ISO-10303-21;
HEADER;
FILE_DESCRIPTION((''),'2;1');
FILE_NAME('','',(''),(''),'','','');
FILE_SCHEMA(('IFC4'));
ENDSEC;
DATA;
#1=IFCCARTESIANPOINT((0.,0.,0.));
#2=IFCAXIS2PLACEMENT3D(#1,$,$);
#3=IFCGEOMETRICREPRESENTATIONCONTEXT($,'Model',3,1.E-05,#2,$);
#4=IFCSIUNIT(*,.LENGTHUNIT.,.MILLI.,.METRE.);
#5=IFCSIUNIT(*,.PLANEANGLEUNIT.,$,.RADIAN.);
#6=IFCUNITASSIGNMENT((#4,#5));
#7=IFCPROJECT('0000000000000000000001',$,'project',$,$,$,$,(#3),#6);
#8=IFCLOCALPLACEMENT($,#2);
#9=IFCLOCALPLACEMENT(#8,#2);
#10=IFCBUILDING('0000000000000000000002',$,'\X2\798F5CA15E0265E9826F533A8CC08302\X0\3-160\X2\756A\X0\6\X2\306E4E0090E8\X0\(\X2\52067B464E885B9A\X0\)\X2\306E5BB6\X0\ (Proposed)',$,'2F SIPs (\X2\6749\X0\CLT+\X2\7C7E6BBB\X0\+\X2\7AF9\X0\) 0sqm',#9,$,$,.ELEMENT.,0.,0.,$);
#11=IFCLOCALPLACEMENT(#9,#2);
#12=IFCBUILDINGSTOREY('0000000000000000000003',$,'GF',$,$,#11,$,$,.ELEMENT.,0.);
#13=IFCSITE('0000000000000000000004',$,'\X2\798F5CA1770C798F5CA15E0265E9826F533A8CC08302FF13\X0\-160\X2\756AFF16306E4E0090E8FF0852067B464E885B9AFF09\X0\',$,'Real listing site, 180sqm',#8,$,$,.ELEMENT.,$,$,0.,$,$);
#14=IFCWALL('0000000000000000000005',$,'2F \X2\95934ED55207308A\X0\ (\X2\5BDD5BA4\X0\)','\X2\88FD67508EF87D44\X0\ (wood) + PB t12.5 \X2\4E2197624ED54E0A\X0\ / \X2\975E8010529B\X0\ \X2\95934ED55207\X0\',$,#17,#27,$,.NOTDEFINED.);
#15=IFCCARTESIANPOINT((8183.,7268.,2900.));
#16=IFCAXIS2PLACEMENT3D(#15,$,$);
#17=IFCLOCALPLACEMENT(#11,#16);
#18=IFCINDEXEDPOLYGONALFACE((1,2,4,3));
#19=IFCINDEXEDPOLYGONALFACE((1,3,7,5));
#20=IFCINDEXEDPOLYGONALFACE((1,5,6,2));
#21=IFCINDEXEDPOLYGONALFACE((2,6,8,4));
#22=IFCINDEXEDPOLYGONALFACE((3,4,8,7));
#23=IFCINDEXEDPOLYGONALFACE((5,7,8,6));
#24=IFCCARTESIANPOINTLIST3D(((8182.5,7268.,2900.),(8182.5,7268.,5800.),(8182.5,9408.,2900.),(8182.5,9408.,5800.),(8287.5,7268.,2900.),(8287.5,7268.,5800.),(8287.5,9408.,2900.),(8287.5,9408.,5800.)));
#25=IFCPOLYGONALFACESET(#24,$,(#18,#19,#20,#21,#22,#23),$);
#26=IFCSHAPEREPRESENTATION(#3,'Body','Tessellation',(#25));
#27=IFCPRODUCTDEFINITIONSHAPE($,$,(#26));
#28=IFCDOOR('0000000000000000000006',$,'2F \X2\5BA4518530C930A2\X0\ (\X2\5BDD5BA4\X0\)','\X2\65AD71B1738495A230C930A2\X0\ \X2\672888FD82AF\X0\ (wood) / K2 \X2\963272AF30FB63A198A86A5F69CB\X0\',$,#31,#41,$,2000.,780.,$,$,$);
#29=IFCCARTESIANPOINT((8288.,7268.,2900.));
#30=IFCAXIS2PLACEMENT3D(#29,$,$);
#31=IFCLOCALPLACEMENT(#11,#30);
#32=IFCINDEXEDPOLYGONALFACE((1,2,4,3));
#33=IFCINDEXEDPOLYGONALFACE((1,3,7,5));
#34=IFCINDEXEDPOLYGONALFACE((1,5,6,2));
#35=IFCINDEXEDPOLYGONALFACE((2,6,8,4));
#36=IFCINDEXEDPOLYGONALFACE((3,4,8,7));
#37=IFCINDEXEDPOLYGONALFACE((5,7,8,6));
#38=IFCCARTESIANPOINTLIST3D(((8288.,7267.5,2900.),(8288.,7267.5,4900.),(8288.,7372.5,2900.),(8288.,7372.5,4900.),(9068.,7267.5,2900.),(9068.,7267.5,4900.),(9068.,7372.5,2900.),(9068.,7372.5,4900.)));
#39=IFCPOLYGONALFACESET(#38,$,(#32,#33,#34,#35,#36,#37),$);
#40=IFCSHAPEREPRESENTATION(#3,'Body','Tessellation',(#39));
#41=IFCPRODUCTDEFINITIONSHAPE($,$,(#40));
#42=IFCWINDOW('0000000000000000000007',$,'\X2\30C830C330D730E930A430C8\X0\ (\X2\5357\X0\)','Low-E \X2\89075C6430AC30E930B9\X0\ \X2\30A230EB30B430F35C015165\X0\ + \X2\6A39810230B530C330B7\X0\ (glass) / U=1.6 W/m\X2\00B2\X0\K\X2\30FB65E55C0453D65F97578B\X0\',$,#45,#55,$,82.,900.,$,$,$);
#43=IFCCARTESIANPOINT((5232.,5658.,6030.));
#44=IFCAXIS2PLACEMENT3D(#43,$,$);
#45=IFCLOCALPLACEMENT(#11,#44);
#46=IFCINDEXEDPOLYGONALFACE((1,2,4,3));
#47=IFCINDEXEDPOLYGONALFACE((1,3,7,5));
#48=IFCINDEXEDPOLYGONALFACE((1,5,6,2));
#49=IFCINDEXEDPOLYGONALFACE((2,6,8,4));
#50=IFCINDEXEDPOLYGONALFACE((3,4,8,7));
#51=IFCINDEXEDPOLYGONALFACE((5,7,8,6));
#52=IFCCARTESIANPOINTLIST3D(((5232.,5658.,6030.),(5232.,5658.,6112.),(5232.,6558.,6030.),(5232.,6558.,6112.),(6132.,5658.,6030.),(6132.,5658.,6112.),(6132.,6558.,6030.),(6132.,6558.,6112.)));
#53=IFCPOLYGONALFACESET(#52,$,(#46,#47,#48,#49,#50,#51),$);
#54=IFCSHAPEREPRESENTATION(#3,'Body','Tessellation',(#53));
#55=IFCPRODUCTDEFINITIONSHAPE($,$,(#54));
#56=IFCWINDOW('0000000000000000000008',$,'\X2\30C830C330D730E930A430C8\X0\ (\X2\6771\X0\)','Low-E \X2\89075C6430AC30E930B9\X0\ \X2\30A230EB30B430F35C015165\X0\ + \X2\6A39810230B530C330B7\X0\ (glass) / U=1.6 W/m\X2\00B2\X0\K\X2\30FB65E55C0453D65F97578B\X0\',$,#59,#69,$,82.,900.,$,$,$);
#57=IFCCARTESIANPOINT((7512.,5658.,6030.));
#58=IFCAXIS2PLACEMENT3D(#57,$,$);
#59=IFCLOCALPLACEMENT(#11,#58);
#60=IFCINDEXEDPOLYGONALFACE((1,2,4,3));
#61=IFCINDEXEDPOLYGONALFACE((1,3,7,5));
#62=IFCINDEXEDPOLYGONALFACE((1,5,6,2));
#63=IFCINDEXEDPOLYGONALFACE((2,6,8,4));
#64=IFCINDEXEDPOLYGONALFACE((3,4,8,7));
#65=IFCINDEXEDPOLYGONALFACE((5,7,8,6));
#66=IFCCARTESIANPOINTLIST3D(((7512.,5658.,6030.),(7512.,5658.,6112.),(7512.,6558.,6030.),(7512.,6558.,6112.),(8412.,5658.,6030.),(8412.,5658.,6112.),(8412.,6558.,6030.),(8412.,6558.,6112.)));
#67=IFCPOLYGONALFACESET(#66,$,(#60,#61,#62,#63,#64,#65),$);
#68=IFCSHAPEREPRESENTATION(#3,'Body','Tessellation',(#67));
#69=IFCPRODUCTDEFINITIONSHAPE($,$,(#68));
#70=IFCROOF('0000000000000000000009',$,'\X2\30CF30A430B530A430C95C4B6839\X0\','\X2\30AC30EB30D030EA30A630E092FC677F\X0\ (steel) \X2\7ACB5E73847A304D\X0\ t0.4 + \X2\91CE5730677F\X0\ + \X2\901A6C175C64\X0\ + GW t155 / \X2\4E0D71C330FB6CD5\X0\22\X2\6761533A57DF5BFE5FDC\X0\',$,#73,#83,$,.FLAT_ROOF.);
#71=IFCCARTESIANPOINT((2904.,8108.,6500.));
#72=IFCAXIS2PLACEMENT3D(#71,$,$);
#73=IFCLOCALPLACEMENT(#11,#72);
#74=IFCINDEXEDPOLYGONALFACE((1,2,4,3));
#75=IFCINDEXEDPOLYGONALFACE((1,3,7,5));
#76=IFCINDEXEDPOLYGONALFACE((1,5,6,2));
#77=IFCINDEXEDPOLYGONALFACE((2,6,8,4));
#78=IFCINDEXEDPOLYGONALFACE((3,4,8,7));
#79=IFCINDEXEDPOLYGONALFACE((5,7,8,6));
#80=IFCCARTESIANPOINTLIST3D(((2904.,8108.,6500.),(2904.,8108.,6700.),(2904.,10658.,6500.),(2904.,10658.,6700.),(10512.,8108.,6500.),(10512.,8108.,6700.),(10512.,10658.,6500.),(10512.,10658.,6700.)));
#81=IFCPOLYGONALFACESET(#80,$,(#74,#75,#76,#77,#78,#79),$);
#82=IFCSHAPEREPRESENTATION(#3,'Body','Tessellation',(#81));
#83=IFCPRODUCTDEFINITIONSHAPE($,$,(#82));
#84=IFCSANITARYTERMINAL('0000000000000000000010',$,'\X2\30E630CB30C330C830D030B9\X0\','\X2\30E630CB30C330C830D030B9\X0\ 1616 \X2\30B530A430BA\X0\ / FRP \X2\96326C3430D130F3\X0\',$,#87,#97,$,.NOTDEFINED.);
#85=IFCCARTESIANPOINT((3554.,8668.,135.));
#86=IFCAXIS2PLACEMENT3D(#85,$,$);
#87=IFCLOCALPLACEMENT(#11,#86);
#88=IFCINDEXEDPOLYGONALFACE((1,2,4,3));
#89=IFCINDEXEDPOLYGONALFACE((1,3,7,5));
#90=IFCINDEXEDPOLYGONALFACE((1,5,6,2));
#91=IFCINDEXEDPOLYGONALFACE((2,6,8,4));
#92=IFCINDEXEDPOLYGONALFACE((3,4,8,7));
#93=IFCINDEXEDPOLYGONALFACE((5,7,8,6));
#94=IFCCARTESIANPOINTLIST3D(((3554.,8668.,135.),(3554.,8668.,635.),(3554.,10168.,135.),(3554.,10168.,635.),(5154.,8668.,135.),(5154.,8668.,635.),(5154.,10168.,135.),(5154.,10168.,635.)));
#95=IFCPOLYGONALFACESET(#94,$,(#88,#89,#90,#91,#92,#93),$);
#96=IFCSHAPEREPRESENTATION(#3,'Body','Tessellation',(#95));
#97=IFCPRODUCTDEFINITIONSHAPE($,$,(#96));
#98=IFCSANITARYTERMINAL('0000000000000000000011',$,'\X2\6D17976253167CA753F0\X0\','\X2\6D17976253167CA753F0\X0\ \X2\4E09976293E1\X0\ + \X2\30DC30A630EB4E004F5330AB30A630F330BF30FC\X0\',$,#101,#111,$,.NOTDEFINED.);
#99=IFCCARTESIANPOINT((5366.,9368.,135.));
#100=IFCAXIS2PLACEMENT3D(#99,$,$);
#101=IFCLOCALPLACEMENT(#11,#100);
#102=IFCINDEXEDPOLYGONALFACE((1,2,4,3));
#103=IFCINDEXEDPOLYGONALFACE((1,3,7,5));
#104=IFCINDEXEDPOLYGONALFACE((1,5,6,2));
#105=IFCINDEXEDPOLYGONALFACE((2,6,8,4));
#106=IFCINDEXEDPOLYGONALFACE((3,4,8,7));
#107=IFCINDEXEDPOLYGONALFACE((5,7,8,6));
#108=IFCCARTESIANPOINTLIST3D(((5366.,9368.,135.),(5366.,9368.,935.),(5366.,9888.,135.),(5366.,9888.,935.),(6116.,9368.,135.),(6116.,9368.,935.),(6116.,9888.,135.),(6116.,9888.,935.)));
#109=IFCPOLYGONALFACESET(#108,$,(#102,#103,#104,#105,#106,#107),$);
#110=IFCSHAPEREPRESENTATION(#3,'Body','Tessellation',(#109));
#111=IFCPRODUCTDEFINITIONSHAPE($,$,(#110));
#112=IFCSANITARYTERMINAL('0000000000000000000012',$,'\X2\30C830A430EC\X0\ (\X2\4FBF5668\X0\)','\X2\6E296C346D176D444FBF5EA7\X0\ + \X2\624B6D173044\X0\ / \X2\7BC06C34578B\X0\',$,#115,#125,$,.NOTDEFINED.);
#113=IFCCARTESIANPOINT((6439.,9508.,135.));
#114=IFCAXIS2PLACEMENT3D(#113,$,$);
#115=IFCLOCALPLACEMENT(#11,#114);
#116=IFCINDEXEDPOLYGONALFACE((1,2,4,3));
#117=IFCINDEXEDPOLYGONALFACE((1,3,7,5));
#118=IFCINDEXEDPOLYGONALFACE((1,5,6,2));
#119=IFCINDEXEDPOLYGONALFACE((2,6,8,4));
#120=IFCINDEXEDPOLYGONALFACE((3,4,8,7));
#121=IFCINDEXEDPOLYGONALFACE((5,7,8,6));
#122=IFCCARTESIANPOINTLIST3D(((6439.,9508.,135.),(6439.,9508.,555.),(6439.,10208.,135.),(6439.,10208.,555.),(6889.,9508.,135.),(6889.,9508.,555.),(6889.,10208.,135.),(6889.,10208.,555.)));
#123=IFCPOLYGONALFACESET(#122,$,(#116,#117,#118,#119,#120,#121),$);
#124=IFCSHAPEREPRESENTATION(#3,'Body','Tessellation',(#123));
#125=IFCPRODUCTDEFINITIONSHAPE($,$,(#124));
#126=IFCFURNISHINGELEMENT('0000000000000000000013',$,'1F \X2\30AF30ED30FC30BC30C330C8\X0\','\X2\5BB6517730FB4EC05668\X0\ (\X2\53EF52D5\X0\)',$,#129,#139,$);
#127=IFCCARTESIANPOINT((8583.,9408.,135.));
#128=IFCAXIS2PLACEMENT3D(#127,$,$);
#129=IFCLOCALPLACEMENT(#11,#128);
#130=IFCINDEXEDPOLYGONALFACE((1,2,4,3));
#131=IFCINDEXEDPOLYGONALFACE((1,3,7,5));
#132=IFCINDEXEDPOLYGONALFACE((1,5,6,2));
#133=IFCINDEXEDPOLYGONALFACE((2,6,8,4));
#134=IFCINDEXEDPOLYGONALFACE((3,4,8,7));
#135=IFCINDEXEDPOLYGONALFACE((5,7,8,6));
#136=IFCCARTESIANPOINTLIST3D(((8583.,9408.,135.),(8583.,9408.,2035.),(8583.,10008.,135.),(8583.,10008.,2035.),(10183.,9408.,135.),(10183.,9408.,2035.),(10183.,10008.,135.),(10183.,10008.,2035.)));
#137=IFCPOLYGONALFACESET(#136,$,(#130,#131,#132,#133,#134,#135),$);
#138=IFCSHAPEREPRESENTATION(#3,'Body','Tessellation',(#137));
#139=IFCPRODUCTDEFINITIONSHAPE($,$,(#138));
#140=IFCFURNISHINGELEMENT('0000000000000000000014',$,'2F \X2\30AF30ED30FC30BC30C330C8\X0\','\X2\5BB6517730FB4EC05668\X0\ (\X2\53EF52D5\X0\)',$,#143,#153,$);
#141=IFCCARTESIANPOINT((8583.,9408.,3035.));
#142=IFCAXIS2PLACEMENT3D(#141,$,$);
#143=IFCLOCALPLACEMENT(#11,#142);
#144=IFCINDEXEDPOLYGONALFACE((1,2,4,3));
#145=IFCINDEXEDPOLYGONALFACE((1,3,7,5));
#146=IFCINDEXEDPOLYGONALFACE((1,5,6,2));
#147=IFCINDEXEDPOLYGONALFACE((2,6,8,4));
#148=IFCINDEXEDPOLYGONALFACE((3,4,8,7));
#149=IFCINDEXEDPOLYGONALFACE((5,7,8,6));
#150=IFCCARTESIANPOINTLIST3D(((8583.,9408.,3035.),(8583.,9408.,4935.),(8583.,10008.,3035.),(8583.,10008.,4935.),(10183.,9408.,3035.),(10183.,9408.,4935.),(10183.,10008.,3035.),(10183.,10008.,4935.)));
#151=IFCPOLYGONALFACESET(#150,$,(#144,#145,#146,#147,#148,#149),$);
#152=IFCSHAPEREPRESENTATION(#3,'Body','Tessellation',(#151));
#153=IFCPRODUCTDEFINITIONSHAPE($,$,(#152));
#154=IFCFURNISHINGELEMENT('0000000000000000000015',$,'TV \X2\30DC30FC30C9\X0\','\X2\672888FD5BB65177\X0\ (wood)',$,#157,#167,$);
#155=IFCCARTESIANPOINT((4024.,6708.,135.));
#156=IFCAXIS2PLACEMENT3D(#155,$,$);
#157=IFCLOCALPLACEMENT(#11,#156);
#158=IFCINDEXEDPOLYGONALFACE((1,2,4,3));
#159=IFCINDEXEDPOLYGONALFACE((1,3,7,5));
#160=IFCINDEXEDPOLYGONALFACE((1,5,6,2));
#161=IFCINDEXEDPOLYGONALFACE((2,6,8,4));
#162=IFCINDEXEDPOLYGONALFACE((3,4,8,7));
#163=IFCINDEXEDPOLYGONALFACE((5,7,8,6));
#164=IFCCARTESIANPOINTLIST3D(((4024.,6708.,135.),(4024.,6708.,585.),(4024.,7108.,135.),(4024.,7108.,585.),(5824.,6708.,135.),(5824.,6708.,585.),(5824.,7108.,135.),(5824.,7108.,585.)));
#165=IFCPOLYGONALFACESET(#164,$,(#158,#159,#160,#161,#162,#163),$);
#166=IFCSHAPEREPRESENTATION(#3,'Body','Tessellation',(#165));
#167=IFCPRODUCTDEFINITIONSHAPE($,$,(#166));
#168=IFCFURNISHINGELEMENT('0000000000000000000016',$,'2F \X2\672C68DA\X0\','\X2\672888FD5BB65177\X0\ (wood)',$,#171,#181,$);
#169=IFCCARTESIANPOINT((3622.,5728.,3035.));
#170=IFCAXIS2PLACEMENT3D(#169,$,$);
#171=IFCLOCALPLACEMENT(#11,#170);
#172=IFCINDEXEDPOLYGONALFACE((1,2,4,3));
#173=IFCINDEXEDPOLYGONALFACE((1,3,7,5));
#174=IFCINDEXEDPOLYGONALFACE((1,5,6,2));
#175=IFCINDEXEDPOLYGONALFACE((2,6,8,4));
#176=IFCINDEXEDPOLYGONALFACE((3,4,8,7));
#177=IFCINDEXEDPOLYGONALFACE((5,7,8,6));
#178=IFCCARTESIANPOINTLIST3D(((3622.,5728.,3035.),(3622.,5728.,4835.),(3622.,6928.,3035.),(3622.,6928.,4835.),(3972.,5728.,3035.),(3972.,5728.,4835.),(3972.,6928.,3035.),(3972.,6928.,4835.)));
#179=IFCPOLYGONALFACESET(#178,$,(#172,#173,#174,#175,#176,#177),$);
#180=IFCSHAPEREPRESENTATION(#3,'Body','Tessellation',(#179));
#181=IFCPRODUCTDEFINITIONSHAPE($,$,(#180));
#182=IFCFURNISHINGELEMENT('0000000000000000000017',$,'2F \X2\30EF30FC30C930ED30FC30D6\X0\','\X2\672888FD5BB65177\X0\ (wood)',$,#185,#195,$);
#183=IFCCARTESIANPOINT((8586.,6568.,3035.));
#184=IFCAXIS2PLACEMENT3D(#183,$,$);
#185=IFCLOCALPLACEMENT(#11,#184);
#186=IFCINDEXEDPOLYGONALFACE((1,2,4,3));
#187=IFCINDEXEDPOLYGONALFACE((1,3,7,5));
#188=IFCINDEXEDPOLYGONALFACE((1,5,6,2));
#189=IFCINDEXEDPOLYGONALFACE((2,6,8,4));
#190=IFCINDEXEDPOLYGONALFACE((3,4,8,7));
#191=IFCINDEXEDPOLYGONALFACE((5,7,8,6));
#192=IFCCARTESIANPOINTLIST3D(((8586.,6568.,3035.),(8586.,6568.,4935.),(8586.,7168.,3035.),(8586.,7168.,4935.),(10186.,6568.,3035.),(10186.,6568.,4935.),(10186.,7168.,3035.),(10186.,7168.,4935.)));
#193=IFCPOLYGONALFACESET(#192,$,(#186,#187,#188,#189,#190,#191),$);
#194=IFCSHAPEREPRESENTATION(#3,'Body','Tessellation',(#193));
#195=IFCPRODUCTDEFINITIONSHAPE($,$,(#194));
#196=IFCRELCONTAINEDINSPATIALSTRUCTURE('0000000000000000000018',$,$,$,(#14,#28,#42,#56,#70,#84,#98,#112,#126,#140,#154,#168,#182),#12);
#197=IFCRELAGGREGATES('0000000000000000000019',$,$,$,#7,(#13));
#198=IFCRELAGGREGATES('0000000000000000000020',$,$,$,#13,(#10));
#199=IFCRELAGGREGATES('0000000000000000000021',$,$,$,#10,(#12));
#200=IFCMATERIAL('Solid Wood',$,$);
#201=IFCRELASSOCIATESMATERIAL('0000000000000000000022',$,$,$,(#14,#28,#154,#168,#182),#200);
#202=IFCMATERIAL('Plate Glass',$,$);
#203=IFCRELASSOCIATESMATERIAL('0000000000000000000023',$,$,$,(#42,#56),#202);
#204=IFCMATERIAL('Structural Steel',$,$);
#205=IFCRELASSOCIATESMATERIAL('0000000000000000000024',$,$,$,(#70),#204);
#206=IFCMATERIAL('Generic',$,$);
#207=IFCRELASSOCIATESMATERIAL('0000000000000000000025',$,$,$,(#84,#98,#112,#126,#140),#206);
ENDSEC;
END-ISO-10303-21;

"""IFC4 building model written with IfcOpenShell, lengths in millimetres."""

from ifc_helpers import new_model, si_unit, frame, frame_2d, origin, place, context, project, spatial, rectangle, extrude, material, element, save


model = new_model("IFC4")

# Units and contexts
model_context = context("Model", 3, precision=1e-05, world=origin())
ifc_project = project(units=[si_unit("LENGTHUNIT", "METRE", prefix="MILLI"), si_unit("PLANEANGLEUNIT", "RADIAN")], contexts=[model_context])

# Site, building, storey
site_placement = place(None, origin())
site = spatial("IfcSite", under=ifc_project, at=site_placement, Name="福岡県福岡市早良区賀茂３-160番６の一部（分筆予定）", ObjectType="Real listing site, 180sqm", CompositionType="ELEMENT", RefElevation=0.0)
building_placement = place(site_placement, origin())
building = spatial("IfcBuilding", under=site, at=building_placement, Name="福岡市早良区賀茂3-160番6の一部(分筆予定)の家 (Proposed)", ObjectType="2F SIPs (杉CLT+籾殻+竹) 0sqm", CompositionType="ELEMENT", ElevationOfRefHeight=0.0, ElevationOfTerrain=0.0)
storey_placement = place(building_placement, origin())
storey = spatial("IfcBuildingStorey", under=building, at=storey_placement, Name="GF", CompositionType="ELEMENT", Elevation=0.0)

# Shared definitions
ifc_material_1 = material(Name="Solid Wood")
ifc_material_2 = material(Name="Plate Glass")

# Wall
wall_1_placement = place(storey_placement, frame((8183.0, 7268.0, 2900.0)))
element("IfcWall", 1, at=wall_1_placement, inside=storey, material=ifc_material_1, Name="2F 間仕切り (寝室)", Description="製材軸組 (wood) + PB t12.5 両面仕上 / 非耐力 間仕切", PredefinedType="NOTDEFINED", context=model_context, shape_type="SweptSolid", body=[
    extrude(rectangle(XDim=105.0, YDim=2140.0, at=frame_2d((52.0, 1070.0))), frame((8183.0, 7268.0, 2900.0)), (0.0, 0.0, 1.0), 2900.0),
])

# Door
door_1_placement = place(storey_placement, frame((8288.0, 7268.0, 2900.0)))
element("IfcDoor", 2, at=door_1_placement, inside=storey, material=ifc_material_1, Name="2F 室内ドア (寝室)", Description="断熱玄関ドア 木製芯 (wood) / K2 防犯・採風機構", OverallHeight=2000.0, OverallWidth=780.0, context=model_context, shape_type="SweptSolid", body=[
    extrude(rectangle(XDim=780.0, YDim=105.0, at=frame_2d((390.0, 52.0))), frame((8288.0, 7268.0, 2900.0)), (0.0, 0.0, 1.0), 2000.0),
])

# Windows
window_1_placement = place(storey_placement, frame((5232.0, 5658.0, 6030.0)))
element("IfcWindow", 3, at=window_1_placement, inside=storey, material=ifc_material_2, Name="トップライト (南)", Description="Low-E 複層ガラス アルゴン封入 + 樹脂サッシ (glass) / U=1.6 W/m²K・日射取得型", OverallHeight=82.0, OverallWidth=900.0, context=model_context, shape_type="SweptSolid", body=[
    extrude(rectangle(XDim=900.0, YDim=900.0, at=frame_2d((450.0, 450.0))), frame((5232.0, 5658.0, 6030.0)), (0.0, 0.0, 1.0), 82.0),
])
window_2_placement = place(storey_placement, frame((7512.0, 5658.0, 6030.0)))
element("IfcWindow", 4, at=window_2_placement, inside=storey, material=ifc_material_2, Name="トップライト (東)", Description="Low-E 複層ガラス アルゴン封入 + 樹脂サッシ (glass) / U=1.6 W/m²K・日射取得型", OverallHeight=82.0, OverallWidth=900.0, context=model_context, shape_type="SweptSolid", body=[
    extrude(rectangle(XDim=900.0, YDim=900.0, at=frame_2d((450.0, 450.0))), frame((7512.0, 5658.0, 6030.0)), (0.0, 0.0, 1.0), 82.0),
])

# Roof
ifc_material_3 = material(Name="Structural Steel")
roof_placement = place(storey_placement, frame((2904.0, 8108.0, 6500.0)))
element("IfcRoof", 5, at=roof_placement, inside=storey, material=ifc_material_3, Name="ハイサイド屋根", Description="ガルバリウム鋼板 (steel) 立平葺き t0.4 + 野地板 + 通気層 + GW t155 / 不燃・法22条区域対応", PredefinedType="FLAT_ROOF", context=model_context, shape_type="SweptSolid", body=[
    extrude(rectangle(XDim=7608.0, YDim=2550.0, at=frame_2d((3804.0, 1275.0))), frame((2904.0, 8108.0, 6500.0)), (0.0, 0.0, 1.0), 200.0),
])

# Sanitary terminals
ifc_material_4 = material(Name="Generic")
sanitary_terminal_1_placement = place(storey_placement, frame((3554.0, 8668.0, 135.0)))
element("IfcSanitaryTerminal", 6, at=sanitary_terminal_1_placement, inside=storey, material=ifc_material_4, Name="ユニットバス", Description="ユニットバス 1616 サイズ / FRP 防水パン", PredefinedType="NOTDEFINED", context=model_context, shape_type="SweptSolid", body=[
    extrude(rectangle(XDim=1600.0, YDim=1500.0, at=frame_2d((800.0, 750.0))), frame((3554.0, 8668.0, 135.0)), (0.0, 0.0, 1.0), 500.0),
])
sanitary_terminal_2_placement = place(storey_placement, frame((5366.0, 9368.0, 135.0)))
element("IfcSanitaryTerminal", 7, at=sanitary_terminal_2_placement, inside=storey, material=ifc_material_4, Name="洗面化粧台", Description="洗面化粧台 三面鏡 + ボウル一体カウンター", PredefinedType="NOTDEFINED", context=model_context, shape_type="SweptSolid", body=[
    extrude(rectangle(XDim=750.0, YDim=520.0, at=frame_2d((375.0, 260.0))), frame((5366.0, 9368.0, 135.0)), (0.0, 0.0, 1.0), 800.0),
])
sanitary_terminal_3_placement = place(storey_placement, frame((6439.0, 9508.0, 135.0)))
element("IfcSanitaryTerminal", 8, at=sanitary_terminal_3_placement, inside=storey, material=ifc_material_4, Name="トイレ (便器)", Description="温水洗浄便座 + 手洗い / 節水型", PredefinedType="NOTDEFINED", context=model_context, shape_type="SweptSolid", body=[
    extrude(rectangle(XDim=450.0, YDim=700.0, at=frame_2d((225.0, 350.0))), frame((6439.0, 9508.0, 135.0)), (0.0, 0.0, 1.0), 420.0),
])

# Furnishing elements
furnishing_1_placement = place(storey_placement, frame((8583.0, 9408.0, 135.0)))
element("IfcFurnishingElement", 9, at=furnishing_1_placement, inside=storey, material=ifc_material_4, Name="1F クローゼット", Description="家具・什器 (可動)", context=model_context, shape_type="SweptSolid", body=[
    extrude(rectangle(XDim=1600.0, YDim=600.0, at=frame_2d((800.0, 300.0))), frame((8583.0, 9408.0, 135.0)), (0.0, 0.0, 1.0), 1900.0),
])
furnishing_2_placement = place(storey_placement, frame((8583.0, 9408.0, 3035.0)))
element("IfcFurnishingElement", 10, at=furnishing_2_placement, inside=storey, material=ifc_material_4, Name="2F クローゼット", Description="家具・什器 (可動)", context=model_context, shape_type="SweptSolid", body=[
    extrude(rectangle(XDim=1600.0, YDim=600.0, at=frame_2d((800.0, 300.0))), frame((8583.0, 9408.0, 3035.0)), (0.0, 0.0, 1.0), 1900.0),
])
furnishing_3_placement = place(storey_placement, frame((4024.0, 6708.0, 135.0)))
element("IfcFurnishingElement", 11, at=furnishing_3_placement, inside=storey, material=ifc_material_1, Name="TV ボード", Description="木製家具 (wood)", context=model_context, shape_type="SweptSolid", body=[
    extrude(rectangle(XDim=1800.0, YDim=400.0, at=frame_2d((900.0, 200.0))), frame((4024.0, 6708.0, 135.0)), (0.0, 0.0, 1.0), 450.0),
])
furnishing_4_placement = place(storey_placement, frame((3622.0, 5728.0, 3035.0)))
element("IfcFurnishingElement", 12, at=furnishing_4_placement, inside=storey, material=ifc_material_1, Name="2F 本棚", Description="木製家具 (wood)", context=model_context, shape_type="SweptSolid", body=[
    extrude(rectangle(XDim=350.0, YDim=1200.0, at=frame_2d((175.0, 600.0))), frame((3622.0, 5728.0, 3035.0)), (0.0, 0.0, 1.0), 1800.0),
])
furnishing_5_placement = place(storey_placement, frame((8586.0, 6568.0, 3035.0)))
element("IfcFurnishingElement", 13, at=furnishing_5_placement, inside=storey, material=ifc_material_1, Name="2F ワードローブ", Description="木製家具 (wood)", context=model_context, shape_type="SweptSolid", body=[
    extrude(rectangle(XDim=1600.0, YDim=600.0, at=frame_2d((800.0, 300.0))), frame((8586.0, 6568.0, 3035.0)), (0.0, 0.0, 1.0), 1900.0),
])

save(model, "model.ifc")
